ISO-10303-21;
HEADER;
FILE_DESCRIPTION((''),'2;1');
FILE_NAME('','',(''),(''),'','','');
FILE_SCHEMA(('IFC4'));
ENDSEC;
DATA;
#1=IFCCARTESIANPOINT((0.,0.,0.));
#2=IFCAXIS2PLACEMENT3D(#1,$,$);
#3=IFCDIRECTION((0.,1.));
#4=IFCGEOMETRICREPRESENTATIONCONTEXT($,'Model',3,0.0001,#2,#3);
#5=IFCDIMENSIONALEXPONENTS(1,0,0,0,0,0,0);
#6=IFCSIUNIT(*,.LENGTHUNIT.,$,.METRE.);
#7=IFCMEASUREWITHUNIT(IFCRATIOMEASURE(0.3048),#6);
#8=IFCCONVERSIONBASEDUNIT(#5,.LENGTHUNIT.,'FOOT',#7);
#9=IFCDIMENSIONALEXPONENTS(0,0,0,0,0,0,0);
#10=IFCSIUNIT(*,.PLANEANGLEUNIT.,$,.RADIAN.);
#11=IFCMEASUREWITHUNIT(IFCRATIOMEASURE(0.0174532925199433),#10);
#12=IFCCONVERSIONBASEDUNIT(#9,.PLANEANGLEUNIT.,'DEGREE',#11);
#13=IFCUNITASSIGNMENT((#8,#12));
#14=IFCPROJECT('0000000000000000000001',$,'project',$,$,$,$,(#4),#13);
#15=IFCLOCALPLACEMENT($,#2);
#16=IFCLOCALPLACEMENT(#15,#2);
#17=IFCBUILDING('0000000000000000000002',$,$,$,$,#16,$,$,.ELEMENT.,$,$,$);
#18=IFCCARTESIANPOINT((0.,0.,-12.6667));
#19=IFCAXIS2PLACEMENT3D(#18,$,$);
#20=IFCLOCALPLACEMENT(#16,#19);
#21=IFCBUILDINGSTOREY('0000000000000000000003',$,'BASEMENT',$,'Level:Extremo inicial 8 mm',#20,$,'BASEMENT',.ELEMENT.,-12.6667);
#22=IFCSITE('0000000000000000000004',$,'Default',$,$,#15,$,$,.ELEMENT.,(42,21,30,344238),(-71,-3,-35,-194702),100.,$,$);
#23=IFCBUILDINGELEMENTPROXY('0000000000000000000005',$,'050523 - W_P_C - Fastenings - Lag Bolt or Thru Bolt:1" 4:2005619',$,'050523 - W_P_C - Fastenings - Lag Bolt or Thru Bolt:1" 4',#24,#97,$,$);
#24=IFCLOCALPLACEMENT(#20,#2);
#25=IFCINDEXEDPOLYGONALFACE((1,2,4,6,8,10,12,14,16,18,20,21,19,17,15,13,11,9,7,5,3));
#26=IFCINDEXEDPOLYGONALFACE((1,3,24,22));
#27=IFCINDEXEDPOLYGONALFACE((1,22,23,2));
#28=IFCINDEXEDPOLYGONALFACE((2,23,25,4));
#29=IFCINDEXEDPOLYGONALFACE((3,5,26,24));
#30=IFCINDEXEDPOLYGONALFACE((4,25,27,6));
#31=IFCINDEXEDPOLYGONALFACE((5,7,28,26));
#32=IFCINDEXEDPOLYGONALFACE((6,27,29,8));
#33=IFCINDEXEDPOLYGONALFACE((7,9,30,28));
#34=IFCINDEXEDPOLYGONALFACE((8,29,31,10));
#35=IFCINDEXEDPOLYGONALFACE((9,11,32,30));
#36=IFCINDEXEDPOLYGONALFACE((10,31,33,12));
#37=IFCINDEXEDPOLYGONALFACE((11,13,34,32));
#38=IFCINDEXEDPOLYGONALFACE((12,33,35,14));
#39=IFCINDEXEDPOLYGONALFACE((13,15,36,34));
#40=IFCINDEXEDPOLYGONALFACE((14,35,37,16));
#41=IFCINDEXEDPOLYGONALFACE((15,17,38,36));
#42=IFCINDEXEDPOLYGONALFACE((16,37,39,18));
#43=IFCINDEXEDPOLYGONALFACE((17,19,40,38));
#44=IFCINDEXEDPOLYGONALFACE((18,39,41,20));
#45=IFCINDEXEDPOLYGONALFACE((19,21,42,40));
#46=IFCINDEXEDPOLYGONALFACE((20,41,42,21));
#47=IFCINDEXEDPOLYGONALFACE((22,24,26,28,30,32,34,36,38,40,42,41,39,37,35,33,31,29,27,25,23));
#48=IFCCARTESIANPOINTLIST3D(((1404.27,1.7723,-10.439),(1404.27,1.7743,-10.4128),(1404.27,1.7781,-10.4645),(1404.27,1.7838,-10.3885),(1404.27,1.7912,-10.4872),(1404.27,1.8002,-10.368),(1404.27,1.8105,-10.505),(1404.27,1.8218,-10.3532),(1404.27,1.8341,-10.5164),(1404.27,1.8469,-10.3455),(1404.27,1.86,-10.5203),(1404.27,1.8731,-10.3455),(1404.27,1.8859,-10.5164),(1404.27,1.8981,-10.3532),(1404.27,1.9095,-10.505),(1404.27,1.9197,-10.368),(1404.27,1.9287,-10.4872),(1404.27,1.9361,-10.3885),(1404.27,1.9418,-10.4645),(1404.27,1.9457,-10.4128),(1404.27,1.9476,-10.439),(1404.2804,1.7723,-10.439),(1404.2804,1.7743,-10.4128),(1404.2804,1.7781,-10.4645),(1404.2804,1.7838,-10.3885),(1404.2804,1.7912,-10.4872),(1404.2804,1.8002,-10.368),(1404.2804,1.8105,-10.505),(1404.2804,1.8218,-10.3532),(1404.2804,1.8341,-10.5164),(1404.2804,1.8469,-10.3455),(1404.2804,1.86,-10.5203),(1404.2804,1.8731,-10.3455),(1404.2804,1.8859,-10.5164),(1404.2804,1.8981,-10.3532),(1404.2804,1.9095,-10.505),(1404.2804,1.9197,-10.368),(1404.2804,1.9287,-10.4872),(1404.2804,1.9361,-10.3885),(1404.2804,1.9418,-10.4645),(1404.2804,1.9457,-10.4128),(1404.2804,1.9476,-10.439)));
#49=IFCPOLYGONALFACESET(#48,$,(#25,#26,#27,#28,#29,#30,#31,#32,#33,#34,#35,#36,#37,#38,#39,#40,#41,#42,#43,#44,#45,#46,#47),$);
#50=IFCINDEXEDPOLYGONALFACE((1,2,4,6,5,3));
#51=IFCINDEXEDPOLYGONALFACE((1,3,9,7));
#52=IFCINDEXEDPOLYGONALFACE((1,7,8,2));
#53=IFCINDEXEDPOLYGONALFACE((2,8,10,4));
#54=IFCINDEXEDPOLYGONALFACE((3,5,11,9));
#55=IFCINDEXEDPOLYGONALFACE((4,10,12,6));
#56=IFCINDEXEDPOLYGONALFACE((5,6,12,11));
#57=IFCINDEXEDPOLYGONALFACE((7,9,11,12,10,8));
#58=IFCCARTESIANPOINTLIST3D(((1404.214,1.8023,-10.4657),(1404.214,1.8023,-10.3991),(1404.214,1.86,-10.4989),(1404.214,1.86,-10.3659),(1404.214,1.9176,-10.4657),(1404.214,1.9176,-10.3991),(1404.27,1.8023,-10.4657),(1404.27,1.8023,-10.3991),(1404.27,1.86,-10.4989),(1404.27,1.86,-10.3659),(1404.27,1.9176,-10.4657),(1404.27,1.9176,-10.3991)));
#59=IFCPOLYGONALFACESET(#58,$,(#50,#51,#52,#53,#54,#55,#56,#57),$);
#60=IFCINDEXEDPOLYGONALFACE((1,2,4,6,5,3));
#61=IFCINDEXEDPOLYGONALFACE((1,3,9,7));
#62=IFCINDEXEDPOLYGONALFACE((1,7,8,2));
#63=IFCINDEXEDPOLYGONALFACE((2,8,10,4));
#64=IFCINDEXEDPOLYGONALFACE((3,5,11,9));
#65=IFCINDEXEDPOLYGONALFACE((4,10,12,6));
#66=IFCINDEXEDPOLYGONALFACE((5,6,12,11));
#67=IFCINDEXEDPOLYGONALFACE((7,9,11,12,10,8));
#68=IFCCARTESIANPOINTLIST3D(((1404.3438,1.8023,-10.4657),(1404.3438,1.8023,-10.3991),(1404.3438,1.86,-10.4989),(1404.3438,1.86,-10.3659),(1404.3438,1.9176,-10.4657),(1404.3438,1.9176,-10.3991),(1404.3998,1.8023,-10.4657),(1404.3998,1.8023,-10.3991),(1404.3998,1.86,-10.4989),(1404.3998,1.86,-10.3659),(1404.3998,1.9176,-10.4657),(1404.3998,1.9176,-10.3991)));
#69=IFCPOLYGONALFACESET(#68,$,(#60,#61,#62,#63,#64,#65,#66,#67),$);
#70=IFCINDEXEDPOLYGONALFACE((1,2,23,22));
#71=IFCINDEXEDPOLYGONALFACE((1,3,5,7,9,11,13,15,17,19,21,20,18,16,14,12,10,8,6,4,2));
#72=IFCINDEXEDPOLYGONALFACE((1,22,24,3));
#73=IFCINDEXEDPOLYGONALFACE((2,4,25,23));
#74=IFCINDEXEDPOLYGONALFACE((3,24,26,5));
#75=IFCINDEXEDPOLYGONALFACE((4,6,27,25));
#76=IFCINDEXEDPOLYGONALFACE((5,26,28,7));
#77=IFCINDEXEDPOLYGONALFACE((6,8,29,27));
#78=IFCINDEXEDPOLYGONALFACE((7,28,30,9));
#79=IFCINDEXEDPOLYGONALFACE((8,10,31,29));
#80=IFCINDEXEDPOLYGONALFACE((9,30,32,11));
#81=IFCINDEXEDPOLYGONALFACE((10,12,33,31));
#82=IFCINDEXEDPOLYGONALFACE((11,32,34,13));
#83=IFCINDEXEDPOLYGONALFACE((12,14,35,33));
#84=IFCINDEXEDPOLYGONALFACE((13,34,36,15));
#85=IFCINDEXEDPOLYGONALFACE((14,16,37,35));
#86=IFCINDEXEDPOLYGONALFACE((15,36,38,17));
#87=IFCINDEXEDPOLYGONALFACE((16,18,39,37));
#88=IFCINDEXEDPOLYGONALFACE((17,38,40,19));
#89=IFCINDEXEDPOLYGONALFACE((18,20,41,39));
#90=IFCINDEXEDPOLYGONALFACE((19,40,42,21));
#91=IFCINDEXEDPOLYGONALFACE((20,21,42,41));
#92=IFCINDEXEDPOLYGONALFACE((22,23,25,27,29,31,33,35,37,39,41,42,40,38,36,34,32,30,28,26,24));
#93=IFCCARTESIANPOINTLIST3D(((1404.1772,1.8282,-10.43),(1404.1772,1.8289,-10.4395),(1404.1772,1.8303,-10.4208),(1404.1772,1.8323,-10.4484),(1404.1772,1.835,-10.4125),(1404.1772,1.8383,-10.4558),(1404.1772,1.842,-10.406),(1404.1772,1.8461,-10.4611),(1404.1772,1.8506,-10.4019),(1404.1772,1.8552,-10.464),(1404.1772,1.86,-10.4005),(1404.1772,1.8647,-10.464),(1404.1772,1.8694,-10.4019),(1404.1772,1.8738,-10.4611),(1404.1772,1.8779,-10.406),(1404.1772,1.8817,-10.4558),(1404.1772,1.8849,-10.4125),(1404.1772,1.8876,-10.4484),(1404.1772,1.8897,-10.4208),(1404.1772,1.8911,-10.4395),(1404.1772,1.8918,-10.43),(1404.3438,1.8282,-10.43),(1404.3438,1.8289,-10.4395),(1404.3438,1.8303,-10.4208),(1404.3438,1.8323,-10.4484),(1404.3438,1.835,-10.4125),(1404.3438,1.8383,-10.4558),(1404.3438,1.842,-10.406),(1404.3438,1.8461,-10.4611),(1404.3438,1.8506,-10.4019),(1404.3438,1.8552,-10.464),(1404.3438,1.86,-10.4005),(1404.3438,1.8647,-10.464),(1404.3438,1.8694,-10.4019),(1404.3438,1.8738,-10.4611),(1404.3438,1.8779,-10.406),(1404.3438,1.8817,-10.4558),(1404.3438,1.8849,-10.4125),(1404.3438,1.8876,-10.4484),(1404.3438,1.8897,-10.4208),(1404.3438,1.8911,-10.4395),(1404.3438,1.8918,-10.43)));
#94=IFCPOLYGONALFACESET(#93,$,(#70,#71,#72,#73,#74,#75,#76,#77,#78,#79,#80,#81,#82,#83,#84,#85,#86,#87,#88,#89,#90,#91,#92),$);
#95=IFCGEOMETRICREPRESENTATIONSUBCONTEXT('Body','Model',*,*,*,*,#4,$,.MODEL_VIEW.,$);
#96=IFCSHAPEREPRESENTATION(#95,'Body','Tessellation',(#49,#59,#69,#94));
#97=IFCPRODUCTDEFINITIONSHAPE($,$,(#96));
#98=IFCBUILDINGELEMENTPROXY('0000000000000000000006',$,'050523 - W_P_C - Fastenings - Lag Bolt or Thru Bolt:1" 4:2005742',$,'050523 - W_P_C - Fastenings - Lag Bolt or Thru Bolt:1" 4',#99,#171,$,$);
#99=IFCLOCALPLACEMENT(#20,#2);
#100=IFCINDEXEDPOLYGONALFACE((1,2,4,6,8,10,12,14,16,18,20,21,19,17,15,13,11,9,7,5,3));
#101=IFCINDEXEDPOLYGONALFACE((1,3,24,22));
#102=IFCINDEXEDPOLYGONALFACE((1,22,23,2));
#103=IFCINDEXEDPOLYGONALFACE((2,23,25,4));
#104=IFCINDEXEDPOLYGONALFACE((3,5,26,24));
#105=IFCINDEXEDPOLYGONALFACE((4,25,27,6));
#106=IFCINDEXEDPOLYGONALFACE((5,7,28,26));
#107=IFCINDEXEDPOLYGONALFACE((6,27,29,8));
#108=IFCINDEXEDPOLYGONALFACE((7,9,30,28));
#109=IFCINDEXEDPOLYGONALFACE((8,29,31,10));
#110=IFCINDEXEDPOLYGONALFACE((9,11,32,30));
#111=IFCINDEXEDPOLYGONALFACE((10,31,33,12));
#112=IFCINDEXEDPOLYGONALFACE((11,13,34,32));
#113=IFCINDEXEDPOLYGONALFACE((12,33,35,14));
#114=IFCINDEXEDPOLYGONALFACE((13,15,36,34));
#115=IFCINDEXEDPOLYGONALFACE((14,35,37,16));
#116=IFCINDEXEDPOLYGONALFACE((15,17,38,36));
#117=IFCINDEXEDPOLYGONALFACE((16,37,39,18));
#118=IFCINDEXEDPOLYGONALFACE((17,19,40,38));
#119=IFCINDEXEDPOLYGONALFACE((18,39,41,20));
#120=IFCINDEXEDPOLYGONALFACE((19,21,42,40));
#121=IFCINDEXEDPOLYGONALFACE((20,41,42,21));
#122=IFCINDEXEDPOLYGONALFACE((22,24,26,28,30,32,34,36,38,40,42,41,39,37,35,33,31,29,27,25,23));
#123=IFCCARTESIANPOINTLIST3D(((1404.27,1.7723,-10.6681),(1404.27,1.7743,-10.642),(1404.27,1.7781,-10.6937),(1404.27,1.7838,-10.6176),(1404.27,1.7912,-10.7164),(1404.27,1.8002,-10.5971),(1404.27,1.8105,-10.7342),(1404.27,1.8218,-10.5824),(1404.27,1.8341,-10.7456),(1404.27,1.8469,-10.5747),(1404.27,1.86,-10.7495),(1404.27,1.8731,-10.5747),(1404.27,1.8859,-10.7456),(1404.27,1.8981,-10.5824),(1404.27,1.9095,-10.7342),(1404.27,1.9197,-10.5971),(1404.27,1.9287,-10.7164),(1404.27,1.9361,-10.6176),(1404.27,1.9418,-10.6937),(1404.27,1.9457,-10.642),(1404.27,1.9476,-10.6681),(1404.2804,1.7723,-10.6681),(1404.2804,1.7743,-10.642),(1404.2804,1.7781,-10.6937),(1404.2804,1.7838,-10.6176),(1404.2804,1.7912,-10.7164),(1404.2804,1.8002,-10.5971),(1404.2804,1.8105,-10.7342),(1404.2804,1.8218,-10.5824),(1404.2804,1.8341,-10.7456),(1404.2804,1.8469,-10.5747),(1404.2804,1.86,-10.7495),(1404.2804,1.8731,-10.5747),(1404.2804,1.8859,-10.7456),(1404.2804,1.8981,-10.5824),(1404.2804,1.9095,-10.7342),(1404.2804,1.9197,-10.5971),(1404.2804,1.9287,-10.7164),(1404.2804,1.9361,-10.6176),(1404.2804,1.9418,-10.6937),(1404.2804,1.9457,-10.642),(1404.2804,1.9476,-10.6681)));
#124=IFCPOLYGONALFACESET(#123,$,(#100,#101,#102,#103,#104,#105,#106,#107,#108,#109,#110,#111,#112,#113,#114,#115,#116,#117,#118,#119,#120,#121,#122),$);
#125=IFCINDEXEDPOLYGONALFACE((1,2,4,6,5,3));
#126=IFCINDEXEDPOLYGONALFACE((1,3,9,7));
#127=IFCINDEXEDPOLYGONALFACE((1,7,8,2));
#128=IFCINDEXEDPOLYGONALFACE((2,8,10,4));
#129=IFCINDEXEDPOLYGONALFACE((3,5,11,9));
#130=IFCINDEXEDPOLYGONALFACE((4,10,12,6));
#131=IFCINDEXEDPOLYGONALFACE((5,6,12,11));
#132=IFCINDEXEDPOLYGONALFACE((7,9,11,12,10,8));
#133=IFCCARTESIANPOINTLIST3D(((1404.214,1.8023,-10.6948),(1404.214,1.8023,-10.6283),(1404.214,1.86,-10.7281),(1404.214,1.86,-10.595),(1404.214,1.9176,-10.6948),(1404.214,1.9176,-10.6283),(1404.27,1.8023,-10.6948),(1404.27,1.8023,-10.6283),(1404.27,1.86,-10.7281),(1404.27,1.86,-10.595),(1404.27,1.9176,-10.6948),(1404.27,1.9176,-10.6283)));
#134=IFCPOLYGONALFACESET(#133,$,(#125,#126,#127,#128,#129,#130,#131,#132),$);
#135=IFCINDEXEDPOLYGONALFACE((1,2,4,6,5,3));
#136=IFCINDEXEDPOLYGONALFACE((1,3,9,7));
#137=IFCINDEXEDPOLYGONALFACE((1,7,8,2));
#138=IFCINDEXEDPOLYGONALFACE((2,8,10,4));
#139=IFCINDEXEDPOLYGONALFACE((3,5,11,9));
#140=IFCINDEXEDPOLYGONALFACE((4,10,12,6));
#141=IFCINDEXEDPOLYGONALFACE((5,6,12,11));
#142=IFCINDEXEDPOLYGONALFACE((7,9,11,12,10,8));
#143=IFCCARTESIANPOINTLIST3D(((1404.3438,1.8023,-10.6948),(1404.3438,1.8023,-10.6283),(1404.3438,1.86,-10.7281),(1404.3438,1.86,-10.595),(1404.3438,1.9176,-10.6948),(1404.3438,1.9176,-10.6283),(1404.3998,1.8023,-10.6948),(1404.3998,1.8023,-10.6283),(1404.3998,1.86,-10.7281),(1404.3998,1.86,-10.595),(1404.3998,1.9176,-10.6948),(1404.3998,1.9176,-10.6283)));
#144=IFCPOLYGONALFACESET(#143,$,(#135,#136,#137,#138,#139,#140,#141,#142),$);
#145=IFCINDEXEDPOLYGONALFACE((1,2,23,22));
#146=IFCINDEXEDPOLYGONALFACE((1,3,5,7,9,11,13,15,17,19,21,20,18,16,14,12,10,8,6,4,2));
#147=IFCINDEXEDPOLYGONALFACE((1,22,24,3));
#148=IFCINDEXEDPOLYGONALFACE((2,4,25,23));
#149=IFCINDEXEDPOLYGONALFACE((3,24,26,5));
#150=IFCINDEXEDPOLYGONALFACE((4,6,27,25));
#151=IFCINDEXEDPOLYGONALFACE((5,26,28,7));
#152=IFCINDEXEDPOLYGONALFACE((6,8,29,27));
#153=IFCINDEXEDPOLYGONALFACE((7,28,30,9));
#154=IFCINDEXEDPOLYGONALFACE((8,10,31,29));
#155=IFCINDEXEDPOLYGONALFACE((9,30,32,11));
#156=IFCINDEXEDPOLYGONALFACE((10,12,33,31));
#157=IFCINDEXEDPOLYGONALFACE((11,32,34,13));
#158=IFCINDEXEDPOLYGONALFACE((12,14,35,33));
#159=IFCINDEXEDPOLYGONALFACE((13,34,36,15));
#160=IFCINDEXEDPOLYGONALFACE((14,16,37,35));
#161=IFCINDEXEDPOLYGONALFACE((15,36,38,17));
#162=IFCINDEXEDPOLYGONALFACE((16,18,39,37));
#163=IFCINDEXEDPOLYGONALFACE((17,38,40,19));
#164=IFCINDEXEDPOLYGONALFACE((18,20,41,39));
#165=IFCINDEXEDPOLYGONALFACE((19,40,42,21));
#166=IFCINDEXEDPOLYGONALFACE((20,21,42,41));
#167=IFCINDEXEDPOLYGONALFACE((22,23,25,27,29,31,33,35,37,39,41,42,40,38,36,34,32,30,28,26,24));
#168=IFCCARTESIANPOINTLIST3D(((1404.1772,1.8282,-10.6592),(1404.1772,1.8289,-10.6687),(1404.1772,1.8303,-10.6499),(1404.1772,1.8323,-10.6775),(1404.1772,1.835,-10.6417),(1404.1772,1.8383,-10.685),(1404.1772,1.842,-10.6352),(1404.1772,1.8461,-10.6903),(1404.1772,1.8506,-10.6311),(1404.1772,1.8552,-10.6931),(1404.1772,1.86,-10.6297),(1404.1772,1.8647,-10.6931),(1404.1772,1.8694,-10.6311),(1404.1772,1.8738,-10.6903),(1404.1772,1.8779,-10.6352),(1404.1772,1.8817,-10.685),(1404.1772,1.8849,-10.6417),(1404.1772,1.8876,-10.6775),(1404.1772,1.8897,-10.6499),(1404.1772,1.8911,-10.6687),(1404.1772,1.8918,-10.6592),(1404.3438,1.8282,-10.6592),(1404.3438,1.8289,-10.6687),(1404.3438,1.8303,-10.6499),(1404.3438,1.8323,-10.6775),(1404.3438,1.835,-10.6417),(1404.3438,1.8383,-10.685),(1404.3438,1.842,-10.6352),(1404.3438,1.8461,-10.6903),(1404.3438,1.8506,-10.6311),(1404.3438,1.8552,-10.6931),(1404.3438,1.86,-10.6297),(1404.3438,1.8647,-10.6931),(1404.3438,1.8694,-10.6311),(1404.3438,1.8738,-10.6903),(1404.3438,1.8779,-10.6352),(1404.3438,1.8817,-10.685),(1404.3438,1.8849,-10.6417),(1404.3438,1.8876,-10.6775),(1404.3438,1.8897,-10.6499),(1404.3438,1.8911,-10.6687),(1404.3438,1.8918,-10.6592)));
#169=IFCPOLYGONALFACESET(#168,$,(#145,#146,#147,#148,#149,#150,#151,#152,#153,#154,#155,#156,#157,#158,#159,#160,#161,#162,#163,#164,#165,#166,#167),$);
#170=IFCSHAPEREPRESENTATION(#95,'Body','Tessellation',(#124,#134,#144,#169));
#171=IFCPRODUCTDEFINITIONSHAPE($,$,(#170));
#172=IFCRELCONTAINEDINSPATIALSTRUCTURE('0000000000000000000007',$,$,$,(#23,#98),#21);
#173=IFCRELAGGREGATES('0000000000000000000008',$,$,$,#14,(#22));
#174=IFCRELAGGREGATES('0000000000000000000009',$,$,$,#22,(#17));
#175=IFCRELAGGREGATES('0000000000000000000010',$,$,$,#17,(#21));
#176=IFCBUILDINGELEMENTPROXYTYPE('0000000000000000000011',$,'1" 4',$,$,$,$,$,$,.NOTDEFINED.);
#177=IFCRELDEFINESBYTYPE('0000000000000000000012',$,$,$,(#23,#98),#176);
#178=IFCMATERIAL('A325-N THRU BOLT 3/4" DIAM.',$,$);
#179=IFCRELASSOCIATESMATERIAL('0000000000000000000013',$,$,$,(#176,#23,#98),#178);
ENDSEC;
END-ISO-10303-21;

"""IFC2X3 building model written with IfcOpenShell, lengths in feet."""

from ifc_helpers import new_model, entity, si_unit, converted_unit, direction, frame, frame_2d, origin, place, context, subcontext, project, spatial, polyline, circle, outline, extrude, source, transform, mapped, material, type_object, type_shapes, element, save


model = new_model("IFC2X3")

# Units and contexts
model_context = context("Model", 3, precision=0.0001, world=origin(), true_north=direction((0.0, 1.0)))
body_context = subcontext(model_context, "Body", "Model", "MODEL_VIEW")
ifc_project = project(units=[converted_unit("LENGTHUNIT", "FOOT", entity("IfcRatioMeasure", 0.3048), si_unit("LENGTHUNIT", "METRE"), dimensions=[1, 0, 0, 0, 0, 0, 0]), converted_unit("PLANEANGLEUNIT", "DEGREE", entity("IfcRatioMeasure", 0.0174532925199433), si_unit("PLANEANGLEUNIT", "RADIAN"), dimensions=[0, 0, 0, 0, 0, 0, 0])], contexts=[model_context])

# Site, building, storey
site_placement = place(None, origin())
site = spatial("IfcSite", under=ifc_project, at=site_placement, Name="Default", CompositionType="ELEMENT", RefLatitude=(42, 21, 30, 344238), RefLongitude=(-71, -3, -35, -194702), RefElevation=100.0)
building_placement = place(site_placement, origin())
building = spatial("IfcBuilding", under=site, at=building_placement, CompositionType="ELEMENT")
storey_placement = place(building_placement, frame((0.0, 0.0, -12.6667)))
storey = spatial("IfcBuildingStorey", under=building, at=storey_placement, Name="BASEMENT", ObjectType="Level:Extremo inicial 8 mm", LongName="BASEMENT", CompositionType="ELEMENT", Elevation=-12.6667)

# Building element proxies
ifc_material_1 = material(Name="A325-N THRU BOLT 3/4\" DIAM.")
building_element_proxy_type_1 = type_object("IfcBuildingElementProxyType", Name="1\" 4", PredefinedType="NOTDEFINED", material=ifc_material_1)
shared_shape_1 = source(origin(), body_context, "Body", "SweptSolid", [
    extrude(circle(Radius=0.0879, at=frame_2d((0.0, 0.0), x_axis=(1.0, 0.0))), frame((0.0, 0.0, -0.0738), z_axis=(0.0, 0.0, 1.0), x_axis=(0.0, -1.0, 0.0)), (0.0, 0.0, 1.0), 0.0104),
    extrude(outline(polyline([(-0.0333, -0.0576), (0.0333, -0.0576), (0.0665, 0.0), (0.0333, 0.0576), (-0.0333, 0.0576), (-0.0665, 0.0), (-0.0333, -0.0576)])), frame((0.0, 0.0, -0.1298), z_axis=(0.0, 0.0, 1.0), x_axis=(0.866025, -0.5, 0.0)), (0.0, 0.0, 1.0), 0.056),
    extrude(outline(polyline([(-0.0333, -0.0576), (0.0333, -0.0576), (0.0665, 0.0), (0.0333, 0.0576), (-0.0333, 0.0576), (-0.0665, 0.0), (-0.0333, -0.0576)])), frame((0.0, 0.0, 0.0), z_axis=(0.0, 0.0, 1.0), x_axis=(0.0, -1.0, 0.0)), (0.0, 0.0, 1.0), 0.056),
    extrude(circle(Radius=0.0319, at=frame_2d((0.0, 0.0), x_axis=(1.0, 0.0))), frame((0.0, 0.0, -0.1667), z_axis=(0.0, 0.0, 1.0), x_axis=(0.0, 1.0, 0.0)), (0.0, 0.0, 1.0), 0.1667),
])
type_shapes(building_element_proxy_type_1, [shared_shape_1])
for number, where, z_axis, x_axis, name in (
    (1, (1404.3438, 1.86, -10.4324), (1.0, 0.0, 0.0), (0.0, 1.0, 0.0), "050523 - W_P_C - Fastenings - Lag Bolt or Thru Bolt:1\" 4:2005619"),
    (2, (1404.3438, 1.86, -10.6616), (1.0, 0.0, 0.0), (0.0, 1.0, 0.0), "050523 - W_P_C - Fastenings - Lag Bolt or Thru Bolt:1\" 4:2005742"),
):
    element("IfcBuildingElementProxy", number, at=place(storey_placement, frame(where, z_axis=z_axis, x_axis=x_axis)), inside=storey, type_object=building_element_proxy_type_1, material=ifc_material_1, Name=name, ObjectType="050523 - W_P_C - Fastenings - Lag Bolt or Thru Bolt:1\" 4", context=body_context, shape_type="MappedRepresentation", body=[
        mapped(shared_shape_1, transform((0.0, 0.0, 0.0), scale=1.0)),
    ])

save(model, "model.ifc")
